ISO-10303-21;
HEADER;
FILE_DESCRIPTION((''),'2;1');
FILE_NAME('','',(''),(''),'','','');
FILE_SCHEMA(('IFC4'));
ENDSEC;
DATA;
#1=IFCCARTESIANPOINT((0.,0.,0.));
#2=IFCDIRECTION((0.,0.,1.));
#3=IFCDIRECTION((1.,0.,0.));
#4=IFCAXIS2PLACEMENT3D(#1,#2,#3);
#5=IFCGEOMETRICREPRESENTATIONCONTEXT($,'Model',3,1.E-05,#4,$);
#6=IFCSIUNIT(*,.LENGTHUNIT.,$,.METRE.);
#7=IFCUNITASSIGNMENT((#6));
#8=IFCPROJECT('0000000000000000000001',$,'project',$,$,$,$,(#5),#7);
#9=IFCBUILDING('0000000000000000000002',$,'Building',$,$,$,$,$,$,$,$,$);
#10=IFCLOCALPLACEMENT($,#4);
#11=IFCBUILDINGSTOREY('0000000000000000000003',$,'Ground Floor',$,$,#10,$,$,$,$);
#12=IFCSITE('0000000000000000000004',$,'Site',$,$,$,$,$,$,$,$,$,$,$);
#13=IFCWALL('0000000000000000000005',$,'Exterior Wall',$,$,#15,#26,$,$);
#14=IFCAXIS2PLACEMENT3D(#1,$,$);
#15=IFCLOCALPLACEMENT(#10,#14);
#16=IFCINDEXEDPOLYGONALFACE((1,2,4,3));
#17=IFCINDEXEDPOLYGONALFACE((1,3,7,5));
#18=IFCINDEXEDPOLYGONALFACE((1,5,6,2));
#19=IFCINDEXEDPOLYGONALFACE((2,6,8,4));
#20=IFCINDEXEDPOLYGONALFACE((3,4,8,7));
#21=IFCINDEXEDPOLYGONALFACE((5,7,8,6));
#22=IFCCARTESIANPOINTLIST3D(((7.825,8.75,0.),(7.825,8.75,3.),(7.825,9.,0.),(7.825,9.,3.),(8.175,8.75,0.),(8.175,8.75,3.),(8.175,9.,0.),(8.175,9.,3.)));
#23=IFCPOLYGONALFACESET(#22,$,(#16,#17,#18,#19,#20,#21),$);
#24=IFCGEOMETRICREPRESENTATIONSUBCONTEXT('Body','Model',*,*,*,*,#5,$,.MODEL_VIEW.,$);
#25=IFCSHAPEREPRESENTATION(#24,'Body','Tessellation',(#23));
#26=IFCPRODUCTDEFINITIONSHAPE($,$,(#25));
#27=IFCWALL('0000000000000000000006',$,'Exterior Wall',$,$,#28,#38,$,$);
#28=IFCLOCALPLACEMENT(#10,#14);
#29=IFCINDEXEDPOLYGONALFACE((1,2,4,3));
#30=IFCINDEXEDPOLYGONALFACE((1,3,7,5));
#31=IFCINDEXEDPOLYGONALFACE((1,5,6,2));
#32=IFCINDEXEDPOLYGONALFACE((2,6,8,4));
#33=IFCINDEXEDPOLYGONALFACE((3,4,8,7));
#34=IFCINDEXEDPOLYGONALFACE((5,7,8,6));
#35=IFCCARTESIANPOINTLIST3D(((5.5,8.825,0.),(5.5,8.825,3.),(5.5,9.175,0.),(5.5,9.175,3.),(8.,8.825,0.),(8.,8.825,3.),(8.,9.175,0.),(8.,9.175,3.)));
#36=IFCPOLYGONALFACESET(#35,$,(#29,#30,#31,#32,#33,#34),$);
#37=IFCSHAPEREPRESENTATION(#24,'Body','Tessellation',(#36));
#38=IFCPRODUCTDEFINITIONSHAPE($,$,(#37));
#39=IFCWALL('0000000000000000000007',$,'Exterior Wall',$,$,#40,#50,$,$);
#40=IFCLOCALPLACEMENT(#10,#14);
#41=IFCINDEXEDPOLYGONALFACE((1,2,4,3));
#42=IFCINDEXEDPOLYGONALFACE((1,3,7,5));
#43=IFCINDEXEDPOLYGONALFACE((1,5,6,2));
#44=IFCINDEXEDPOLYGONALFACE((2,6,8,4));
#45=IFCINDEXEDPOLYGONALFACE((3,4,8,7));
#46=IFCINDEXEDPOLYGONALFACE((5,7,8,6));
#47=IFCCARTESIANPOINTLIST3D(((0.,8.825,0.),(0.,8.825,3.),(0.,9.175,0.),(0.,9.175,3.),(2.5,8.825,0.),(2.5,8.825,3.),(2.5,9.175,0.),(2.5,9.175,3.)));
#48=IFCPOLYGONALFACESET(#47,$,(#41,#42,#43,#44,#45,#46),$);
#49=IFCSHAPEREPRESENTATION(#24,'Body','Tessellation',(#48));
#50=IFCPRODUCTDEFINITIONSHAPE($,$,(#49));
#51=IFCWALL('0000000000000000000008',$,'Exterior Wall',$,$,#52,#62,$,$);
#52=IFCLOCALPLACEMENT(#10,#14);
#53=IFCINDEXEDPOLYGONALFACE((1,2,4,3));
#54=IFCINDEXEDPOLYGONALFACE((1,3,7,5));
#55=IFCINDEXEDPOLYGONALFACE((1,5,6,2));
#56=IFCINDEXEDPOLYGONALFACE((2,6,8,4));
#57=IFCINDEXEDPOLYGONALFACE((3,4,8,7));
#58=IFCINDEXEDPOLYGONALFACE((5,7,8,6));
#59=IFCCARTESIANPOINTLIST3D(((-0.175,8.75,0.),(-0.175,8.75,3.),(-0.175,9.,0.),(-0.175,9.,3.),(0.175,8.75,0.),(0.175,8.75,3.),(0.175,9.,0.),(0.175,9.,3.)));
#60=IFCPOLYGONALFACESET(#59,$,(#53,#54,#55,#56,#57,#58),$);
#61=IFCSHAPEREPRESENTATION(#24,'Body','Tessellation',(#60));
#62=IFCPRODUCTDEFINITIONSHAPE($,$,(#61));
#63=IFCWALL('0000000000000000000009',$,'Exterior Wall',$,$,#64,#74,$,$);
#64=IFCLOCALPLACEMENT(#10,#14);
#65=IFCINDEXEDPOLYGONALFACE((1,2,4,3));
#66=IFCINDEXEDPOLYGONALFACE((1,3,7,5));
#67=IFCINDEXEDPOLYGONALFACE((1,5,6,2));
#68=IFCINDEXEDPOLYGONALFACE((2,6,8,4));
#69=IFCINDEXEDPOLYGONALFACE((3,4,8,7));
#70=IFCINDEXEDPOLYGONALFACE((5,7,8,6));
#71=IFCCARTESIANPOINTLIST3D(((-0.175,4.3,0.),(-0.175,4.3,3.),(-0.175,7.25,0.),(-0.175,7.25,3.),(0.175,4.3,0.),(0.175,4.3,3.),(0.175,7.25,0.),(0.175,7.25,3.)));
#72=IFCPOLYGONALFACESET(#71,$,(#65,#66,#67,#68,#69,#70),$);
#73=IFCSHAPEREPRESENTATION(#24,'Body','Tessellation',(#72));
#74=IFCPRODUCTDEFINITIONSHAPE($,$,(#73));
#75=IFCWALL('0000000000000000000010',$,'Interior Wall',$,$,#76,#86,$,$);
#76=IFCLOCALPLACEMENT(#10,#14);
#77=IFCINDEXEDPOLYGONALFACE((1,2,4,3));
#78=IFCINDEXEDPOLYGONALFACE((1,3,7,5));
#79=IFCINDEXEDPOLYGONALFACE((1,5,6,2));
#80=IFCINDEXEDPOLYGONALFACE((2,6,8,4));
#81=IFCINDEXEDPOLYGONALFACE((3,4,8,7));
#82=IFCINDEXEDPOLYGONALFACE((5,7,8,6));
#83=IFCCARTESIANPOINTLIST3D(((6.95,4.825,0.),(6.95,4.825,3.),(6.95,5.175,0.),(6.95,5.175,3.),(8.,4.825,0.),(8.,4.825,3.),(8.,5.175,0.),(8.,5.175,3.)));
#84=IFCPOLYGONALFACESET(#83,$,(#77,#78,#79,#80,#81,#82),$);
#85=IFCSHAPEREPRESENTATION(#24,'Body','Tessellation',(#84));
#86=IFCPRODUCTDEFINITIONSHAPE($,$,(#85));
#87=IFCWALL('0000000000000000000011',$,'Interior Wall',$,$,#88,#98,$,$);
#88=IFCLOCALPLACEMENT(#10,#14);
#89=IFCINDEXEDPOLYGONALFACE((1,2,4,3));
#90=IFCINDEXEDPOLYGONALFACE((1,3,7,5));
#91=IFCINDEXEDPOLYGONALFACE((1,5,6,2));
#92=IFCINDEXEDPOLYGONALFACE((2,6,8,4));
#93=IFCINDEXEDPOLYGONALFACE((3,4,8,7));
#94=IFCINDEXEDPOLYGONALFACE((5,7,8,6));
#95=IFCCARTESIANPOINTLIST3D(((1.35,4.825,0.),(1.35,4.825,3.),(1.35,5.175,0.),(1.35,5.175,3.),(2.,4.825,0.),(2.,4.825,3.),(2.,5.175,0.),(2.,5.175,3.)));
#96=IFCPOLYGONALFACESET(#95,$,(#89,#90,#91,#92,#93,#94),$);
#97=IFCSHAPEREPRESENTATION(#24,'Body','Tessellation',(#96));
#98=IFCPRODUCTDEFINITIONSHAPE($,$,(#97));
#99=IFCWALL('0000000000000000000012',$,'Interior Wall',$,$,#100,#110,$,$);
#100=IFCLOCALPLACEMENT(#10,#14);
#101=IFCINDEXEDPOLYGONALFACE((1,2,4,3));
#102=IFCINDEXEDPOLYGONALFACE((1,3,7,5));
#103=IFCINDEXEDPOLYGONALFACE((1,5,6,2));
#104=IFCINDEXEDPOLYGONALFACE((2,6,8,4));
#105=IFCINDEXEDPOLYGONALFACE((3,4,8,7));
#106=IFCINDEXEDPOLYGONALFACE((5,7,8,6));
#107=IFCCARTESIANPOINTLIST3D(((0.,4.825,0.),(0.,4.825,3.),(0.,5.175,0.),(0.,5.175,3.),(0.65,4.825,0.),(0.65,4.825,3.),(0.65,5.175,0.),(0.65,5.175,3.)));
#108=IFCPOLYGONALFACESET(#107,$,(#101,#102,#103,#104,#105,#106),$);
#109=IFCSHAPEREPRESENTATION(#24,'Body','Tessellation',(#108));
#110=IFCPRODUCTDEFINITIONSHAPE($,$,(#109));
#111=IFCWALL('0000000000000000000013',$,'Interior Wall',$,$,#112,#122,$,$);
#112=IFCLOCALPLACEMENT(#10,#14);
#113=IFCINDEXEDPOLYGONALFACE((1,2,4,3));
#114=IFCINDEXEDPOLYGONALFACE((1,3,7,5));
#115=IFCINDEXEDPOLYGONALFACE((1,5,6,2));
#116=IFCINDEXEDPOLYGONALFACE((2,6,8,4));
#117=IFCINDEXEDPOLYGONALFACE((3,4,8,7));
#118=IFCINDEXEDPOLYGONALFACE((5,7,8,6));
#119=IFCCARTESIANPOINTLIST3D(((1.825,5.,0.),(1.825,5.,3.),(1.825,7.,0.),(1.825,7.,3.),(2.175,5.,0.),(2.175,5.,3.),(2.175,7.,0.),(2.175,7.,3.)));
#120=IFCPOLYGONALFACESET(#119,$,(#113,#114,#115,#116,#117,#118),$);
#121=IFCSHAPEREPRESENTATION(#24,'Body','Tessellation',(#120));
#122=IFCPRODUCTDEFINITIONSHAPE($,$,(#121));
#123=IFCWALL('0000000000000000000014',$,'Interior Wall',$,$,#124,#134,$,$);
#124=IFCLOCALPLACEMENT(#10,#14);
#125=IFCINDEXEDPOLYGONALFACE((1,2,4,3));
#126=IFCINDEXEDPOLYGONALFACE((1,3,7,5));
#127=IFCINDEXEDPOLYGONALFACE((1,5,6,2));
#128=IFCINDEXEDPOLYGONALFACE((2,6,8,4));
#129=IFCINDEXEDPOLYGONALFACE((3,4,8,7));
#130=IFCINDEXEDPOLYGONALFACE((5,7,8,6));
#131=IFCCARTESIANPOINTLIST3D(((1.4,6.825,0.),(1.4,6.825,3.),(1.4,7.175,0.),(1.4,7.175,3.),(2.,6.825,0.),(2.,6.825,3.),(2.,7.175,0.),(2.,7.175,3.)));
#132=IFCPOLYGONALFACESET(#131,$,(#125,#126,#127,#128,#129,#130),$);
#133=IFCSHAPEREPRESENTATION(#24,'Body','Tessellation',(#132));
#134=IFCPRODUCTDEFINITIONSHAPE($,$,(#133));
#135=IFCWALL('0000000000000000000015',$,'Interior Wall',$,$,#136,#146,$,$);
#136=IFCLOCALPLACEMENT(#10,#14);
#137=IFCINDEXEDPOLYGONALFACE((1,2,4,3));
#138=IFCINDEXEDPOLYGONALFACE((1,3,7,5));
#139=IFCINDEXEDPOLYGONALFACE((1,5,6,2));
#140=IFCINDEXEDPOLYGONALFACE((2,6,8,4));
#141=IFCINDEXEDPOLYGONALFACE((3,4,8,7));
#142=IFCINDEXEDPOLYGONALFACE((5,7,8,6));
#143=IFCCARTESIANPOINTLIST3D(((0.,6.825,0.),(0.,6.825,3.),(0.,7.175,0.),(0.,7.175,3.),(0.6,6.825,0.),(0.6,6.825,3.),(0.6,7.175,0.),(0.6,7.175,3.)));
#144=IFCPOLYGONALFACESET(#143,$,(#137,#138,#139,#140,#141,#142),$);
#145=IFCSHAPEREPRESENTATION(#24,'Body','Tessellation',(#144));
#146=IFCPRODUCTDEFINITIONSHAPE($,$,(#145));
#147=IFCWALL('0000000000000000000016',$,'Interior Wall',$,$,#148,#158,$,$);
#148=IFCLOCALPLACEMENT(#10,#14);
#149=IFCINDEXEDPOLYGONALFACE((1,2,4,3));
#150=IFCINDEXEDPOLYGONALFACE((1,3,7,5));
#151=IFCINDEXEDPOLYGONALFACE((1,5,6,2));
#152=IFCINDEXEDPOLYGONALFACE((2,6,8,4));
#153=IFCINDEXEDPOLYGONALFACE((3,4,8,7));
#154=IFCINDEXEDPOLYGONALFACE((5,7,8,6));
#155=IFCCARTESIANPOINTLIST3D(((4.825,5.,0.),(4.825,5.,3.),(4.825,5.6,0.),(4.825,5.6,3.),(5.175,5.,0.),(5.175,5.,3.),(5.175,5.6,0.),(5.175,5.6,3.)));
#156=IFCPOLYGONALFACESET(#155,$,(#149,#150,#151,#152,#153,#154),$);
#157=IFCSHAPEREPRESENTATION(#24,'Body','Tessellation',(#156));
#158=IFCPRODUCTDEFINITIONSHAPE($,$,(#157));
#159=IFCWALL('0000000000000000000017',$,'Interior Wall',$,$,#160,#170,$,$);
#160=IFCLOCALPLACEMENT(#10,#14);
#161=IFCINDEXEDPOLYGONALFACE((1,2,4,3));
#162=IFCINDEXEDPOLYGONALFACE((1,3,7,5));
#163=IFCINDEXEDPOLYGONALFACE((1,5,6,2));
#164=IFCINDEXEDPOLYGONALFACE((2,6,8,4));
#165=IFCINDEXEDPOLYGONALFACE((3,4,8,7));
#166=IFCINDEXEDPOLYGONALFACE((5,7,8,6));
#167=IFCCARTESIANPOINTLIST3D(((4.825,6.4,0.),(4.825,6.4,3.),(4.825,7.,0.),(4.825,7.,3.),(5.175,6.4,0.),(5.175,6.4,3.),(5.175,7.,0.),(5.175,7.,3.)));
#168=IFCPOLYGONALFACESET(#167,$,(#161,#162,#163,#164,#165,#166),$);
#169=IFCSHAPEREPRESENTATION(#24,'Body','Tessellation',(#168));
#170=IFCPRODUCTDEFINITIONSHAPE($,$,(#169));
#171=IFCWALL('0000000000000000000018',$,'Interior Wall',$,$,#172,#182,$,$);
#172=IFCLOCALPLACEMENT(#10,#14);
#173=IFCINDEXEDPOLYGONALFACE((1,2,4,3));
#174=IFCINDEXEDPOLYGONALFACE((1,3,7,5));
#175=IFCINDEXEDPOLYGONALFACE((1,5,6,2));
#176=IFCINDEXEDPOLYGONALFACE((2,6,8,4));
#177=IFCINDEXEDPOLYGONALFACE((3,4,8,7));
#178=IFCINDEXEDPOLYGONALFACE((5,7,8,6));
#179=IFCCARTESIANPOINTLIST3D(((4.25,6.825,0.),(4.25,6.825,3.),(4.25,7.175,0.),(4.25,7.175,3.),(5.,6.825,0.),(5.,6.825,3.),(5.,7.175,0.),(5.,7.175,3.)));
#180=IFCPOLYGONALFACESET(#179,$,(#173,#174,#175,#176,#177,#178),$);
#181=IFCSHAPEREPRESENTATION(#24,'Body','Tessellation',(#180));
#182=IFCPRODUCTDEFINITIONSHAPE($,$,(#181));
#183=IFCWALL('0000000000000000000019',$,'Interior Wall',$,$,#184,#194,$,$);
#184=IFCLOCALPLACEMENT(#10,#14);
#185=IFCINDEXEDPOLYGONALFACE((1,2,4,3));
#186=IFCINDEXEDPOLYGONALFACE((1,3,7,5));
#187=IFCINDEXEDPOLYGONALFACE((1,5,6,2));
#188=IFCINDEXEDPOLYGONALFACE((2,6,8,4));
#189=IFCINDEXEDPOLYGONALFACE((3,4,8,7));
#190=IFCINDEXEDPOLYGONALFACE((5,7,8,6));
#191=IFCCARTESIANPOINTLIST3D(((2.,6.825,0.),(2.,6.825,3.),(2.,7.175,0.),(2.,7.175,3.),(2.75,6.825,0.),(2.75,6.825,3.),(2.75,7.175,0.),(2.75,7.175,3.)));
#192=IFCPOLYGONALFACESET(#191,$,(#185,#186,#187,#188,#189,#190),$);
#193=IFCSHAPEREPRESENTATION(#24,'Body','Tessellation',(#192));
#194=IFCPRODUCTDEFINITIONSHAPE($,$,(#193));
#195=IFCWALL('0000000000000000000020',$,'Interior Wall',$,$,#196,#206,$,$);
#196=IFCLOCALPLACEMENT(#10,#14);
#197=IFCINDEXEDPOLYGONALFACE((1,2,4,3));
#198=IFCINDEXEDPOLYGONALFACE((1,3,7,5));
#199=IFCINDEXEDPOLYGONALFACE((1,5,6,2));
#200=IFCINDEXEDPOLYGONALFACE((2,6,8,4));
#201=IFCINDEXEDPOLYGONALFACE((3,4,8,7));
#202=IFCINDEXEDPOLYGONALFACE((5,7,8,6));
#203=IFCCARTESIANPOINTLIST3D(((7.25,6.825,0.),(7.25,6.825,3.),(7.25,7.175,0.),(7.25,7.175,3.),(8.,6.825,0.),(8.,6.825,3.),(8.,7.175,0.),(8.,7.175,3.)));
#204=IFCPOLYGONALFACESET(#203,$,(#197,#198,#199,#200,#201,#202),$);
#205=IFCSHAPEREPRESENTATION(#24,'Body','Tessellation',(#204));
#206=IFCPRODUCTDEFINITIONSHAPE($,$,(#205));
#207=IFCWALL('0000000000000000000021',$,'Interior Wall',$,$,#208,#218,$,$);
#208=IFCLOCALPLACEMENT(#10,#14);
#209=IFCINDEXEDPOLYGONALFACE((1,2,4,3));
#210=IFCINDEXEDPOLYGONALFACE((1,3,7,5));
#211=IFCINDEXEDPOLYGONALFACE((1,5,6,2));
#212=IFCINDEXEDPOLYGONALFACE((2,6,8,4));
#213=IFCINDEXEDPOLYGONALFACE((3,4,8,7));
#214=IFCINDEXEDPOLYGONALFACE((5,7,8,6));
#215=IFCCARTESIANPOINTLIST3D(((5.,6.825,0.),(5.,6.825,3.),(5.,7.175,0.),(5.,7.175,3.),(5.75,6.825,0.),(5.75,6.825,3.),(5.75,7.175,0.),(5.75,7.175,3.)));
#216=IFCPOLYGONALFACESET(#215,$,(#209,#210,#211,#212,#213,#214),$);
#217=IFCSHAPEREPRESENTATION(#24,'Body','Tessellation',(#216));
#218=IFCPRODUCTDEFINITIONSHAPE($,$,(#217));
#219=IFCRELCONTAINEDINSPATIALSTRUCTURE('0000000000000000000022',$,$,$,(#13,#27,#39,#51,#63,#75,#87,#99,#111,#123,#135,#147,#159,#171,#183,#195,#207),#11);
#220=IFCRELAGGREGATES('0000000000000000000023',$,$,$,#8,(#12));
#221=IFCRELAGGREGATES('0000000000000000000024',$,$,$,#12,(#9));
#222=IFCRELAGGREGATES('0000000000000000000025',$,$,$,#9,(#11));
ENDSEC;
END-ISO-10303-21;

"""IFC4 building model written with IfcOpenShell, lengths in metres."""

from ifc_helpers import new_model, si_unit, frame, origin_with_axes, place, context, subcontext, project, spatial, indexed_curve, outline, extrude, element, save


model = new_model("IFC4")

# Units and contexts
model_context = context("Model", 3, precision=1e-05, world=origin_with_axes())
body_context = subcontext(model_context, "Body", "Model", "MODEL_VIEW")
ifc_project = project(units=[si_unit("LENGTHUNIT", "METRE")], contexts=[model_context])

# Site, building, storey
site = spatial("IfcSite", under=ifc_project, Name="Site")
building = spatial("IfcBuilding", under=site, Name="Building")
storey_placement = place(None, origin_with_axes())
storey = spatial("IfcBuildingStorey", under=building, at=storey_placement, Name="Ground Floor")

# Walls
wall_1_placement = place(storey_placement, frame((8.0, 8.75, 0.0), z_axis=(0.0, 0.0, 1.0), x_axis=(0.0, 1.0, 0.0)))
element("IfcWall", 1, at=wall_1_placement, inside=storey, Name="Exterior Wall", context=body_context, shape_type="SweptSolid", body=[
    extrude(outline(indexed_curve([(0.0, 0.0), (0.0, 0.35), (0.25, 0.35), (0.25, 0.0), (0.0, 0.0)], self_intersect=False)), frame((0.0, -0.175, 0.0), z_axis=(0.0, 0.0, 1.0), x_axis=(1.0, 0.0, 0.0)), (0.0, 0.0, 1.0), 3.0),
])
for number, where, z_axis, x_axis, name in (
    (2, (8.0, 9.0, 0.0), (0.0, 0.0, 1.0), (-1.0, 0.0, 0.0), "Exterior Wall"),
    (3, (2.5, 9.0, 0.0), (0.0, 0.0, 1.0), (-1.0, 0.0, 0.0), "Exterior Wall"),
):
    element("IfcWall", number, at=place(storey_placement, frame(where, z_axis=z_axis, x_axis=x_axis)), inside=storey, Name=name, context=body_context, shape_type="SweptSolid", body=[
        extrude(outline(indexed_curve([(0.0, 0.0), (0.0, 0.35), (2.5, 0.35), (2.5, 0.0), (0.0, 0.0)], self_intersect=False)), frame((0.0, -0.175, 0.0), z_axis=(0.0, 0.0, 1.0), x_axis=(1.0, 0.0, 0.0)), (0.0, 0.0, 1.0), 3.0),
    ])
wall_2_placement = place(storey_placement, frame((0.0, 9.0, 0.0), z_axis=(0.0, 0.0, 1.0), x_axis=(0.0, -1.0, 0.0)))
element("IfcWall", 4, at=wall_2_placement, inside=storey, Name="Exterior Wall", context=body_context, shape_type="SweptSolid", body=[
    extrude(outline(indexed_curve([(0.0, 0.0), (0.0, 0.35), (0.25, 0.35), (0.25, 0.0), (0.0, 0.0)], self_intersect=False)), frame((0.0, -0.175, 0.0), z_axis=(0.0, 0.0, 1.0), x_axis=(1.0, 0.0, 0.0)), (0.0, 0.0, 1.0), 3.0),
])
wall_3_placement = place(storey_placement, frame((0.0, 7.25, 0.0), z_axis=(0.0, 0.0, 1.0), x_axis=(0.0, -1.0, 0.0)))
element("IfcWall", 5, at=wall_3_placement, inside=storey, Name="Exterior Wall", context=body_context, shape_type="SweptSolid", body=[
    extrude(outline(indexed_curve([(0.0, 0.0), (0.0, 0.35), (2.95, 0.35), (2.95, 0.0), (0.0, 0.0)], self_intersect=False)), frame((0.0, -0.175, 0.0), z_axis=(0.0, 0.0, 1.0), x_axis=(1.0, 0.0, 0.0)), (0.0, 0.0, 1.0), 3.0),
])
wall_4_placement = place(storey_placement, frame((8.0, 5.0, 0.0), z_axis=(0.0, 0.0, 1.0), x_axis=(-1.0, 0.0, 0.0)))
element("IfcWall", 6, at=wall_4_placement, inside=storey, Name="Interior Wall", context=body_context, shape_type="SweptSolid", body=[
    extrude(outline(indexed_curve([(0.0, 0.0), (0.0, 0.35), (1.05, 0.35), (1.05, 0.0), (0.0, 0.0)], self_intersect=False)), frame((0.0, -0.175, 0.0), z_axis=(0.0, 0.0, 1.0), x_axis=(1.0, 0.0, 0.0)), (0.0, 0.0, 1.0), 3.0),
])
for number, where, z_axis, x_axis, name in (
    (7, (2.0, 5.0, 0.0), (0.0, 0.0, 1.0), (-1.0, 0.0, 0.0), "Interior Wall"),
    (8, (0.65, 5.0, 0.0), (0.0, 0.0, 1.0), (-1.0, 0.0, 0.0), "Interior Wall"),
):
    element("IfcWall", number, at=place(storey_placement, frame(where, z_axis=z_axis, x_axis=x_axis)), inside=storey, Name=name, context=body_context, shape_type="SweptSolid", body=[
        extrude(outline(indexed_curve([(0.0, 0.0), (0.0, 0.35), (0.65, 0.35), (0.65, 0.0), (0.0, 0.0)], self_intersect=False)), frame((0.0, -0.175, 0.0), z_axis=(0.0, 0.0, 1.0), x_axis=(1.0, 0.0, 0.0)), (0.0, 0.0, 1.0), 3.0),
    ])
wall_5_placement = place(storey_placement, frame((2.0, 5.0, 0.0), z_axis=(0.0, 0.0, 1.0), x_axis=(0.0, 1.0, 0.0)))
element("IfcWall", 9, at=wall_5_placement, inside=storey, Name="Interior Wall", context=body_context, shape_type="SweptSolid", body=[
    extrude(outline(indexed_curve([(0.0, 0.0), (0.0, 0.35), (2.0, 0.35), (2.0, 0.0), (0.0, 0.0)], self_intersect=False)), frame((0.0, -0.175, 0.0), z_axis=(0.0, 0.0, 1.0), x_axis=(1.0, 0.0, 0.0)), (0.0, 0.0, 1.0), 3.0),
])
for number, where, z_axis, x_axis, name in (
    (10, (2.0, 7.0, 0.0), (0.0, 0.0, 1.0), (-1.0, 0.0, 0.0), "Interior Wall"),
    (11, (0.6, 7.0, 0.0), (0.0, 0.0, 1.0), (-1.0, 0.0, 0.0), "Interior Wall"),
):
    element("IfcWall", number, at=place(storey_placement, frame(where, z_axis=z_axis, x_axis=x_axis)), inside=storey, Name=name, context=body_context, shape_type="SweptSolid", body=[
        extrude(outline(indexed_curve([(0.0, 0.0), (0.0, 0.35), (0.6, 0.35), (0.6, 0.0), (0.0, 0.0)], self_intersect=False)), frame((0.0, -0.175, 0.0), z_axis=(0.0, 0.0, 1.0), x_axis=(1.0, 0.0, 0.0)), (0.0, 0.0, 1.0), 3.0),
    ])
for number, where, z_axis, x_axis, name in (
    (12, (5.0, 5.0, 0.0), (0.0, 0.0, 1.0), (0.0, 1.0, 0.0), "Interior Wall"),
    (13, (5.0, 6.4, 0.0), (0.0, 0.0, 1.0), (0.0, 1.0, 0.0), "Interior Wall"),
):
    element("IfcWall", number, at=place(storey_placement, frame(where, z_axis=z_axis, x_axis=x_axis)), inside=storey, Name=name, context=body_context, shape_type="SweptSolid", body=[
        extrude(outline(indexed_curve([(0.0, 0.0), (0.0, 0.35), (0.6, 0.35), (0.6, 0.0), (0.0, 0.0)], self_intersect=False)), frame((0.0, -0.175, 0.0), z_axis=(0.0, 0.0, 1.0), x_axis=(1.0, 0.0, 0.0)), (0.0, 0.0, 1.0), 3.0),
    ])
for number, where, z_axis, x_axis, name in (
    (14, (5.0, 7.0, 0.0), (0.0, 0.0, 1.0), (-1.0, 0.0, 0.0), "Interior Wall"),
    (15, (2.75, 7.0, 0.0), (0.0, 0.0, 1.0), (-1.0, 0.0, 0.0), "Interior Wall"),
    (16, (8.0, 7.0, 0.0), (0.0, 0.0, 1.0), (-1.0, 0.0, 0.0), "Interior Wall"),
    (17, (5.75, 7.0, 0.0), (0.0, 0.0, 1.0), (-1.0, 0.0, 0.0), "Interior Wall"),
):
    element("IfcWall", number, at=place(storey_placement, frame(where, z_axis=z_axis, x_axis=x_axis)), inside=storey, Name=name, context=body_context, shape_type="SweptSolid", body=[
        extrude(outline(indexed_curve([(0.0, 0.0), (0.0, 0.35), (0.75, 0.35), (0.75, 0.0), (0.0, 0.0)], self_intersect=False)), frame((0.0, -0.175, 0.0), z_axis=(0.0, 0.0, 1.0), x_axis=(1.0, 0.0, 0.0)), (0.0, 0.0, 1.0), 3.0),
    ])

save(model, "model.ifc")
